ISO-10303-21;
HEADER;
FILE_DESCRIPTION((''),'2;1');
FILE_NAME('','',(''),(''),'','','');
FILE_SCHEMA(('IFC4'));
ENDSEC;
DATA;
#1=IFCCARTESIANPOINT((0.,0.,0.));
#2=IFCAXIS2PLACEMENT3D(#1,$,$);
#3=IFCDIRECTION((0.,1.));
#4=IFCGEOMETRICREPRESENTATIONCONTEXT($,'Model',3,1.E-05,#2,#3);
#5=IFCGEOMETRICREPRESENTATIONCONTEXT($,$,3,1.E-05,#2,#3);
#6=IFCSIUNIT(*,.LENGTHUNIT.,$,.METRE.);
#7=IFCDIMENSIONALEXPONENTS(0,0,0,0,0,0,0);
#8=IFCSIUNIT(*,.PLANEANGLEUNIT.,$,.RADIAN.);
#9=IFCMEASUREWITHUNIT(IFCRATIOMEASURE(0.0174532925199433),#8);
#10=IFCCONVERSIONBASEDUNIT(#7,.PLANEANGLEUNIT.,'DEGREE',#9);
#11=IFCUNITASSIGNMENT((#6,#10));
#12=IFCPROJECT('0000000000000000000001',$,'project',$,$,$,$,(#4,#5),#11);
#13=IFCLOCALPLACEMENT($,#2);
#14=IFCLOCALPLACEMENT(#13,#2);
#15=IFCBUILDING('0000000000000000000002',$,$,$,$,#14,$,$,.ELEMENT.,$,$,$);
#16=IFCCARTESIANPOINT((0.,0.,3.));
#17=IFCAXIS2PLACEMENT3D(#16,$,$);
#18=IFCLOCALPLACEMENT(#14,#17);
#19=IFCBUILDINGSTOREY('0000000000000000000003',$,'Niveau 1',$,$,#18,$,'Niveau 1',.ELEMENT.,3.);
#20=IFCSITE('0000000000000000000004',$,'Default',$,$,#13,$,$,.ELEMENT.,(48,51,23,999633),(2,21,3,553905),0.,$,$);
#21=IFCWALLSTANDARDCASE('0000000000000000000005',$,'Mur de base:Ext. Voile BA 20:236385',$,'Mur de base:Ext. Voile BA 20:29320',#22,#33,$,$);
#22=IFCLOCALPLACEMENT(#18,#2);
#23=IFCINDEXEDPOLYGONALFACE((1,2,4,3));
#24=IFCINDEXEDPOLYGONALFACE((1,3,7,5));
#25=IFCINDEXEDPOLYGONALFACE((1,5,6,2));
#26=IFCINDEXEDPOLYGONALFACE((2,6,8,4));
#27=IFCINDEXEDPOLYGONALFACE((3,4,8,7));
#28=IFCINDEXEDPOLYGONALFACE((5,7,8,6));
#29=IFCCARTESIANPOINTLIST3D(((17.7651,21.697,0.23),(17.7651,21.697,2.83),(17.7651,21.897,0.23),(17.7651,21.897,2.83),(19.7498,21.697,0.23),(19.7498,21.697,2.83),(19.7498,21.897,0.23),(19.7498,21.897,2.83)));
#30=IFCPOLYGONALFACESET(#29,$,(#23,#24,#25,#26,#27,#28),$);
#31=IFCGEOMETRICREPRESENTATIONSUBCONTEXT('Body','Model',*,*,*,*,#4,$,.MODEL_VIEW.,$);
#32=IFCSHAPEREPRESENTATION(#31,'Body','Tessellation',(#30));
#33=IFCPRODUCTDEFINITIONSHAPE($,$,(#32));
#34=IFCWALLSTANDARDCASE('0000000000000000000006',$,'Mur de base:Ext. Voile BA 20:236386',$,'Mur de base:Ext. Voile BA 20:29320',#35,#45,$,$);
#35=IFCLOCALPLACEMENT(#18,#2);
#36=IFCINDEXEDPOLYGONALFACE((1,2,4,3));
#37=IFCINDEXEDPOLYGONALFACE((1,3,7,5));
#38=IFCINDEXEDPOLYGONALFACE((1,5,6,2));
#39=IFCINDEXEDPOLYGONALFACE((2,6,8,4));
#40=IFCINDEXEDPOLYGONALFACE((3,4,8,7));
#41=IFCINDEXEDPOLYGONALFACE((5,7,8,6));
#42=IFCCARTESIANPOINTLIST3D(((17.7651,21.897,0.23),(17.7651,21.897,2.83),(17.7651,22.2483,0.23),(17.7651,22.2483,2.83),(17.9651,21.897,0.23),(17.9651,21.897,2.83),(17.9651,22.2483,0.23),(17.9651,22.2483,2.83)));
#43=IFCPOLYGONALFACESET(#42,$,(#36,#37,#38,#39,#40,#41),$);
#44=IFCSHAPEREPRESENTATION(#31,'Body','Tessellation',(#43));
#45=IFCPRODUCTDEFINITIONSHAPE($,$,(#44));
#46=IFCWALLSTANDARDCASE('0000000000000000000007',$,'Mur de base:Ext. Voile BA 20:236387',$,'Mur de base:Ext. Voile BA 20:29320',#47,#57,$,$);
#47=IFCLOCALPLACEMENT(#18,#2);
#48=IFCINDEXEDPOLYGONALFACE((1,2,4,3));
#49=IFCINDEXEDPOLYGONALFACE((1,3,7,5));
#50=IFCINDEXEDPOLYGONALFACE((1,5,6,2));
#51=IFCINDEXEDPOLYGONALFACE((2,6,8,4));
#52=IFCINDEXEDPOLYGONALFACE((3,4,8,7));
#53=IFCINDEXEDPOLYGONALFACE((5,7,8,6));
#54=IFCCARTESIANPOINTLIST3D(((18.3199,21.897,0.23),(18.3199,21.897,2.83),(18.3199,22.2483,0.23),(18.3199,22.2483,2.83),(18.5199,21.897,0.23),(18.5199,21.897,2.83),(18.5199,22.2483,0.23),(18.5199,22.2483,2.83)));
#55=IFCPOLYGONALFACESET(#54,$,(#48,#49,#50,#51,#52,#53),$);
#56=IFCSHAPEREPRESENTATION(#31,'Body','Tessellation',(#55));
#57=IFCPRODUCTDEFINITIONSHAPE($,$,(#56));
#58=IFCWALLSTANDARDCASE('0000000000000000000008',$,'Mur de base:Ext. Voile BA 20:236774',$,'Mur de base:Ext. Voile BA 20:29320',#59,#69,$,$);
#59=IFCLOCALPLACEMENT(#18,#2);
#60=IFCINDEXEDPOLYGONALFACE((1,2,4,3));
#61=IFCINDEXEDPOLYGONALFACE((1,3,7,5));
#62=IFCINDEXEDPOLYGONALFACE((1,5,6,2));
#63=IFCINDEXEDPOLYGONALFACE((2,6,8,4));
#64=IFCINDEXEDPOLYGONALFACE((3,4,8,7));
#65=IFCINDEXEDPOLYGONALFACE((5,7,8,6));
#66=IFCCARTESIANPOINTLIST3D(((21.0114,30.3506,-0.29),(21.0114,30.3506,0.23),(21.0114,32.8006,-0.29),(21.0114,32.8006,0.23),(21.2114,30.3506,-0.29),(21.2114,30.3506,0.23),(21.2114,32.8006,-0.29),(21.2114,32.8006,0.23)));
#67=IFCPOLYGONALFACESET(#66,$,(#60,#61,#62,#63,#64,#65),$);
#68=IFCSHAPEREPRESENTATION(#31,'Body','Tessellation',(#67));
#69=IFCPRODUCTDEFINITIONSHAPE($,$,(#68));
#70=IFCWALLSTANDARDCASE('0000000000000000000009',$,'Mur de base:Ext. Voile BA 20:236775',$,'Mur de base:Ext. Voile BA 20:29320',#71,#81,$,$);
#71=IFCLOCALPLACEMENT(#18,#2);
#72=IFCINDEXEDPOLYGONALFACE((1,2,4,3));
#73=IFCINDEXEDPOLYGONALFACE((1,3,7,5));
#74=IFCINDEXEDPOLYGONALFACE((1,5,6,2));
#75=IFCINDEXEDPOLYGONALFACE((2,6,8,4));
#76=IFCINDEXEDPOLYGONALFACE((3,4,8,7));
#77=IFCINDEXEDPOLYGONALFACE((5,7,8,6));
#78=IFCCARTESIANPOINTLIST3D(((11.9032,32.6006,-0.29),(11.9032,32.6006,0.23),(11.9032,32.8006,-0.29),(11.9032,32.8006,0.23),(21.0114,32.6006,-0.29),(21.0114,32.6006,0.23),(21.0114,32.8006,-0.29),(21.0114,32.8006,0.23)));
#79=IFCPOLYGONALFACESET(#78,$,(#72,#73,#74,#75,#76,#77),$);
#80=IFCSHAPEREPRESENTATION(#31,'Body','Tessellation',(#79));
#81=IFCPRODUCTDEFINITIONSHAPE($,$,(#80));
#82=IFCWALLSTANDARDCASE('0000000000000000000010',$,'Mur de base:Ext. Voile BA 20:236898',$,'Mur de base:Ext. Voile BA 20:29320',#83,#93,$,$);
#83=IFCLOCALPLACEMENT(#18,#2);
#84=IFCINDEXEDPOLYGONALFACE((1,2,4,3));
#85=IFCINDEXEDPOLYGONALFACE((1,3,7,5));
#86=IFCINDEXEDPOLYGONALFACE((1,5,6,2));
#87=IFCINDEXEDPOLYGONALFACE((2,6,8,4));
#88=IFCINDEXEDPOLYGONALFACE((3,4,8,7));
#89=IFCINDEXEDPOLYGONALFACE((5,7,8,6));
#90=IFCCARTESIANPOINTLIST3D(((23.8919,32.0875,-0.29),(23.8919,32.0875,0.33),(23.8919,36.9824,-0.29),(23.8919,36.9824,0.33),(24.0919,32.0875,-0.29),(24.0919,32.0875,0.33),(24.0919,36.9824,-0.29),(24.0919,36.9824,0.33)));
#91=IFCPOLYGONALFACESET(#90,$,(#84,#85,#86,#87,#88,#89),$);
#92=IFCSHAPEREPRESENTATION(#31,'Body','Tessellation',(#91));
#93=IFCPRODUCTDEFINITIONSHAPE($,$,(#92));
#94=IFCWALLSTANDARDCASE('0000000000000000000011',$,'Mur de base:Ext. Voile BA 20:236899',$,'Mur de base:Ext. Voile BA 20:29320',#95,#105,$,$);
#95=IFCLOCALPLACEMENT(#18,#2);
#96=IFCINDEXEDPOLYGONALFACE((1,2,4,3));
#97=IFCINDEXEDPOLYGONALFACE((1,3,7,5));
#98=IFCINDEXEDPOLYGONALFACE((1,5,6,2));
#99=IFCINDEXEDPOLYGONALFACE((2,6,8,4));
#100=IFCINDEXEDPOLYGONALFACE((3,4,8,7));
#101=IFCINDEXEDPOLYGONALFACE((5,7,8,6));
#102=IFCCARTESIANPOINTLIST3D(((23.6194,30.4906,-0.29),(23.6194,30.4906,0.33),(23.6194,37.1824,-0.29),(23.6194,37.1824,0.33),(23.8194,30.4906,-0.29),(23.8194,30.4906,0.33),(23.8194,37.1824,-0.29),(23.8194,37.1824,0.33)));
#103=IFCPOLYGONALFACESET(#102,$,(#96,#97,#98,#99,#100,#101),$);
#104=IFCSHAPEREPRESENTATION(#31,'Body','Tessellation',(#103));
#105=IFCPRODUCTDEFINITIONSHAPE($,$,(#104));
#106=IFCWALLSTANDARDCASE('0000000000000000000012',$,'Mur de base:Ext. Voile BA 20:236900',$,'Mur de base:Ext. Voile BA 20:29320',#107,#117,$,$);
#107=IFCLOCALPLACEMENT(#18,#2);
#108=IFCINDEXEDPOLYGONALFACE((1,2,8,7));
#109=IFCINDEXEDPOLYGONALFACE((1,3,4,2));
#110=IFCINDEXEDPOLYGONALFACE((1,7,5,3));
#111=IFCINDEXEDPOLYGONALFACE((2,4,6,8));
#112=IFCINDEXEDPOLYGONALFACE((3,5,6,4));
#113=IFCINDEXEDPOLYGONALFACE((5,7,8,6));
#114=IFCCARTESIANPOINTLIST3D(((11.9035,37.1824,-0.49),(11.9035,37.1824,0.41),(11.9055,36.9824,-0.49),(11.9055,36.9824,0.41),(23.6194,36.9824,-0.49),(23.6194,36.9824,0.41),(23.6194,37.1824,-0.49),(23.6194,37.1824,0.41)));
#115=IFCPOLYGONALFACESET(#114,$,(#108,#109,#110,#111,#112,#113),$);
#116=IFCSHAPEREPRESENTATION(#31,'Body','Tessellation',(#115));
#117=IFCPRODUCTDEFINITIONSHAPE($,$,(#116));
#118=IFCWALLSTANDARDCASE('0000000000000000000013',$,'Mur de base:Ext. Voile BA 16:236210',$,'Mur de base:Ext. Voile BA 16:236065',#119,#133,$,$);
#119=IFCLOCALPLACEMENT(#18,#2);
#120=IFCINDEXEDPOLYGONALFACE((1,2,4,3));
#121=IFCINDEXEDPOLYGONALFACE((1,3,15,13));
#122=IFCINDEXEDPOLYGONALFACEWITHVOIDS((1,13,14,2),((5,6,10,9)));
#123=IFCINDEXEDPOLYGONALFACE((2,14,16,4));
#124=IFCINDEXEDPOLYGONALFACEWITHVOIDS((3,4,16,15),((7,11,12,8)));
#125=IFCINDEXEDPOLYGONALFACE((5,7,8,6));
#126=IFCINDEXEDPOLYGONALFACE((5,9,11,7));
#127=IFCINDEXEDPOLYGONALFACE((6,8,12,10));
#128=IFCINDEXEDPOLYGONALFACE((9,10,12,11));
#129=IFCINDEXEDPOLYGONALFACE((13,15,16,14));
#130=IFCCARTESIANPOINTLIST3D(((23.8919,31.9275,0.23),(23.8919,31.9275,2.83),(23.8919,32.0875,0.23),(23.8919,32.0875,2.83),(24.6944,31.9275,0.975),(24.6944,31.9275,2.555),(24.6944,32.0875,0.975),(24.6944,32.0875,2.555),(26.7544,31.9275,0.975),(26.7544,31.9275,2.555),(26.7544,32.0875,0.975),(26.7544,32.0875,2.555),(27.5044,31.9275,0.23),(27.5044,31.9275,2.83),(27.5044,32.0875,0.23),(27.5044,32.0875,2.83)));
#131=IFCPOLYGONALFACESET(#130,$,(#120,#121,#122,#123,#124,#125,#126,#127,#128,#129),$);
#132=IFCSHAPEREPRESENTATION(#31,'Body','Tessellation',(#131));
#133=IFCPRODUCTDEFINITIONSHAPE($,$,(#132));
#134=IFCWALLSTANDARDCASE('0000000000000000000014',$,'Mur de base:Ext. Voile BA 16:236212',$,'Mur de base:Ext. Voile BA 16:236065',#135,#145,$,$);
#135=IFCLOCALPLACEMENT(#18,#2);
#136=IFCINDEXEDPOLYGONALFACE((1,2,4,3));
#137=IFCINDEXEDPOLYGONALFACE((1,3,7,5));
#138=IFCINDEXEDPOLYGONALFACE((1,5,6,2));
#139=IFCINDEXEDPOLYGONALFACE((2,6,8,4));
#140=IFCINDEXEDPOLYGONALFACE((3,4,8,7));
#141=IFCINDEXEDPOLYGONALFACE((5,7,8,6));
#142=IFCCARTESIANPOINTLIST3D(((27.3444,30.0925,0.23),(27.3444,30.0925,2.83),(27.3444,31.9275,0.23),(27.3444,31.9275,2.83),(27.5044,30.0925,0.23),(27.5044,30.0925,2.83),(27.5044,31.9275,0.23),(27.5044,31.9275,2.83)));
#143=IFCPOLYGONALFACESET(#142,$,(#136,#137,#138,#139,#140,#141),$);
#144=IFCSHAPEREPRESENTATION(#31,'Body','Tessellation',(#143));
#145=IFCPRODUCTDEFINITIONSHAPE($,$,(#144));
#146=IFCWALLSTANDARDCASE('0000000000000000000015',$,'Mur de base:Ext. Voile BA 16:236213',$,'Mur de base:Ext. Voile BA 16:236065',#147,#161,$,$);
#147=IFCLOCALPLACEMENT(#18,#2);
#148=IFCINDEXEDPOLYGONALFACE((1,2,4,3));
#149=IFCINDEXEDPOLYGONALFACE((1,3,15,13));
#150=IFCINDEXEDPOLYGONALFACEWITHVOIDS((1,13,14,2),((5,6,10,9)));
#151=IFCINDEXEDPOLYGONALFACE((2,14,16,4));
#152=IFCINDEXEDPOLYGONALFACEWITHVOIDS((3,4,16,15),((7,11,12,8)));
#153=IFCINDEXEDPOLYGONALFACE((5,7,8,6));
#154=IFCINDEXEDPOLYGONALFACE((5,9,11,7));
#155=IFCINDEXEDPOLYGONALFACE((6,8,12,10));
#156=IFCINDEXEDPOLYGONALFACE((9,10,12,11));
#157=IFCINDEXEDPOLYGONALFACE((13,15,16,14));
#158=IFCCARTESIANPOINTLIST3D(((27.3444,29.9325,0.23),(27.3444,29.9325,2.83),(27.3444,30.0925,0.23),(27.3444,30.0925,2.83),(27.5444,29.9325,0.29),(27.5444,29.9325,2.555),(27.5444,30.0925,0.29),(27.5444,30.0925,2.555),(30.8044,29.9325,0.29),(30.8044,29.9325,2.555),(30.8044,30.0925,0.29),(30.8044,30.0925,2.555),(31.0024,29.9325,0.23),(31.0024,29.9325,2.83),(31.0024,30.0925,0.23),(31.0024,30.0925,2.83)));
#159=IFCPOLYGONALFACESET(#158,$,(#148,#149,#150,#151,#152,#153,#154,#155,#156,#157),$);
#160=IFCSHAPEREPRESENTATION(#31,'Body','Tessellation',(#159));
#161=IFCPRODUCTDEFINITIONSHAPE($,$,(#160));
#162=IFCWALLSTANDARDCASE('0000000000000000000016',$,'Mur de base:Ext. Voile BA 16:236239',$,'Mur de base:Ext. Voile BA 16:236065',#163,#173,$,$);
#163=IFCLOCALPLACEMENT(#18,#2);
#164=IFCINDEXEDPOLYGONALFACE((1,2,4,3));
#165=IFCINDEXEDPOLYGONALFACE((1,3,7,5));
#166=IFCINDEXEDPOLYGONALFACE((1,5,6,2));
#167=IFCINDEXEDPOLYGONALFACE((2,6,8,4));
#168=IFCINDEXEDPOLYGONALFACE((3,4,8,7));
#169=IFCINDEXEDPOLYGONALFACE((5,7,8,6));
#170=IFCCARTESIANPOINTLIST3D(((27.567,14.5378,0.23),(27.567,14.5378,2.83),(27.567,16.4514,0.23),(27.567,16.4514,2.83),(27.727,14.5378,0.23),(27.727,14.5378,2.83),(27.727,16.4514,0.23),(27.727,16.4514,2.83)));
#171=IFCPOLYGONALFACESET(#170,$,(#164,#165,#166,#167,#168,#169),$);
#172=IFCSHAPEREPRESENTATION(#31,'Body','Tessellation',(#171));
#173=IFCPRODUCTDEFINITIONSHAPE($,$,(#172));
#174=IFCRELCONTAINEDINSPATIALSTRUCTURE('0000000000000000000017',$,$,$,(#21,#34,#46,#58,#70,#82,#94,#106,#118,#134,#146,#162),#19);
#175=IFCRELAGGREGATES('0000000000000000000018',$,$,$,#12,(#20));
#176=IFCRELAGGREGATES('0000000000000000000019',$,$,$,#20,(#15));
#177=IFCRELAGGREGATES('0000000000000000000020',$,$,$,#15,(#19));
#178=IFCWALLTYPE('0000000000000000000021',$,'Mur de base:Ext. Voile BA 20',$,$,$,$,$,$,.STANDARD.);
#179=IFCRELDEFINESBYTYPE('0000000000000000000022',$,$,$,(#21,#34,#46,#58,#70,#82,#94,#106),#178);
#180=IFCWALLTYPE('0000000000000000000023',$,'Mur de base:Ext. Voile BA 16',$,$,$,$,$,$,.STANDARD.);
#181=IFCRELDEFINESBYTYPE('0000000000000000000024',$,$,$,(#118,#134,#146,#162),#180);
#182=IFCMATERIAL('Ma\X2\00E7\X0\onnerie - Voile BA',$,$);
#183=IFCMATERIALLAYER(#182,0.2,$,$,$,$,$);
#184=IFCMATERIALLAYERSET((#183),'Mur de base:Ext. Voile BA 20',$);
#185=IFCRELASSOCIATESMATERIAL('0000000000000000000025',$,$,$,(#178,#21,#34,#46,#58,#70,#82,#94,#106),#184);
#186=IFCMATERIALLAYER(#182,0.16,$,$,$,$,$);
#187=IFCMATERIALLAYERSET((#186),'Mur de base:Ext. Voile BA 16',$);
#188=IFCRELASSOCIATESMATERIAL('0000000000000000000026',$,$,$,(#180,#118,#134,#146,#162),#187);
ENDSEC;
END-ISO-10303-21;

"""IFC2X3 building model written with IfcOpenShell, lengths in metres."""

from ifc_helpers import new_model, entity, si_unit, converted_unit, direction, frame, frame_2d, origin, origin_2d_with_axis, place, context, subcontext, project, spatial, polyline, rectangle, outline, extrude, material, layer, layer_set, layer_usage, type_object, element, save


model = new_model("IFC2X3")

# Units and contexts
model_context = context("Model", 3, precision=1e-05, world=origin(), true_north=direction((0.0, 1.0)))
context_of_model = context(None, 3, precision=1e-05, world=origin(), true_north=direction((0.0, 1.0)))
body_context = subcontext(model_context, "Body", "Model", "MODEL_VIEW")
ifc_project = project(units=[si_unit("LENGTHUNIT", "METRE"), converted_unit("PLANEANGLEUNIT", "DEGREE", entity("IfcRatioMeasure", 0.0174532925199433), si_unit("PLANEANGLEUNIT", "RADIAN"), dimensions=[0, 0, 0, 0, 0, 0, 0])], contexts=[model_context, context_of_model])

# Site, building, storey
site_placement = place(None, origin())
site = spatial("IfcSite", under=ifc_project, at=site_placement, Name="Default", CompositionType="ELEMENT", RefLatitude=(48, 51, 23, 999633), RefLongitude=(2, 21, 3, 553905), RefElevation=0.0)
building_placement = place(site_placement, origin())
building = spatial("IfcBuilding", under=site, at=building_placement, CompositionType="ELEMENT")
storey_placement = place(building_placement, frame((0.0, 0.0, 3.0)))
storey = spatial("IfcBuildingStorey", under=building, at=storey_placement, Name="Niveau 1", LongName="Niveau 1", CompositionType="ELEMENT", Elevation=3.0)

# Shared definitions
ifc_material = material(Name="Maçonnerie - Voile BA")
ifc_layer_1 = layer(ifc_material, 0.2)
ifc_layer_set_1 = layer_set([ifc_layer_1], Name="Mur de base:Ext. Voile BA 20")
wall_type_1 = type_object("IfcWallType", Name="Mur de base:Ext. Voile BA 20", PredefinedType="STANDARD", material=ifc_layer_set_1)

# Walls
ifc_layer_usage_1 = layer_usage(ifc_layer_set_1, "AXIS2", "NEGATIVE", 0.1)
wall_1_placement = place(storey_placement, frame((19.7498, 21.797, 0.23), z_axis=(0.0, 0.0, 1.0), x_axis=(-1.0, 0.0, 0.0)))
element("IfcWallStandardCase", 1, at=wall_1_placement, inside=storey, type_object=wall_type_1, material=ifc_layer_usage_1, Name="Mur de base:Ext. Voile BA 20:236385", ObjectType="Mur de base:Ext. Voile BA 20:29320", context=body_context, shape_type="SweptSolid", body=[
    extrude(rectangle(XDim=1.9848, YDim=0.2, at=frame_2d((0.9924, 0.0), x_axis=(-1.0, 0.0))), origin(), (0.0, 0.0, 1.0), 2.6),
])
ifc_layer_usage_2 = layer_usage(ifc_layer_set_1, "AXIS2", "NEGATIVE", 0.1)
wall_2_placement = place(storey_placement, frame((17.8651, 22.2483, 0.23), z_axis=(0.0, 0.0, 1.0), x_axis=(0.0, -1.0, 0.0)))
element("IfcWallStandardCase", 2, at=wall_2_placement, inside=storey, type_object=wall_type_1, material=ifc_layer_usage_2, Name="Mur de base:Ext. Voile BA 20:236386", ObjectType="Mur de base:Ext. Voile BA 20:29320", context=body_context, shape_type="SweptSolid", body=[
    extrude(rectangle(XDim=0.3513, YDim=0.2, at=frame_2d((0.1756, 0.0), x_axis=(-1.0, 0.0))), origin(), (0.0, 0.0, 1.0), 2.6),
])
ifc_layer_usage_3 = layer_usage(ifc_layer_set_1, "AXIS2", "NEGATIVE", 0.1)
wall_3_placement = place(storey_placement, frame((18.4199, 22.2483, 0.23), z_axis=(0.0, 0.0, 1.0), x_axis=(0.0, -1.0, 0.0)))
element("IfcWallStandardCase", 3, at=wall_3_placement, inside=storey, type_object=wall_type_1, material=ifc_layer_usage_3, Name="Mur de base:Ext. Voile BA 20:236387", ObjectType="Mur de base:Ext. Voile BA 20:29320", context=body_context, shape_type="SweptSolid", body=[
    extrude(rectangle(XDim=0.3513, YDim=0.2, at=frame_2d((0.1756, 0.0), x_axis=(-1.0, 0.0))), origin(), (0.0, 0.0, 1.0), 2.6),
])
ifc_layer_usage_4 = layer_usage(ifc_layer_set_1, "AXIS2", "NEGATIVE", 0.1)
wall_4_placement = place(storey_placement, frame((21.1114, 30.3506, -0.29), z_axis=(0.0, 0.0, 1.0), x_axis=(0.0, 1.0, 0.0)))
element("IfcWallStandardCase", 4, at=wall_4_placement, inside=storey, type_object=wall_type_1, material=ifc_layer_usage_4, Name="Mur de base:Ext. Voile BA 20:236774", ObjectType="Mur de base:Ext. Voile BA 20:29320", context=body_context, shape_type="SweptSolid", body=[
    extrude(rectangle(XDim=2.45, YDim=0.2, at=frame_2d((1.225, 0.0), x_axis=(-1.0, 0.0))), origin(), (0.0, 0.0, 1.0), 0.52),
])
ifc_layer_usage_5 = layer_usage(ifc_layer_set_1, "AXIS2", "NEGATIVE", 0.1)
wall_5_placement = place(storey_placement, frame((21.0114, 32.7006, -0.29), z_axis=(0.0, 0.0, 1.0), x_axis=(-1.0, 0.0, 0.0)))
element("IfcWallStandardCase", 5, at=wall_5_placement, inside=storey, type_object=wall_type_1, material=ifc_layer_usage_5, Name="Mur de base:Ext. Voile BA 20:236775", ObjectType="Mur de base:Ext. Voile BA 20:29320", context=body_context, shape_type="SweptSolid", body=[
    extrude(rectangle(XDim=9.1082, YDim=0.2, at=frame_2d((4.5541, 0.0), x_axis=(-1.0, 0.0))), origin(), (0.0, 0.0, 1.0), 0.52),
])
ifc_layer_usage_6 = layer_usage(ifc_layer_set_1, "AXIS2", "NEGATIVE", 0.1)
wall_6_placement = place(storey_placement, frame((23.9919, 32.0875, -0.29), z_axis=(0.0, 0.0, 1.0), x_axis=(0.0, 1.0, 0.0)))
element("IfcWallStandardCase", 6, at=wall_6_placement, inside=storey, type_object=wall_type_1, material=ifc_layer_usage_6, Name="Mur de base:Ext. Voile BA 20:236898", ObjectType="Mur de base:Ext. Voile BA 20:29320", context=body_context, shape_type="SweptSolid", body=[
    extrude(rectangle(XDim=4.8949, YDim=0.2, at=frame_2d((2.4475, 0.0), x_axis=(-1.0, 0.0))), origin(), (0.0, 0.0, 1.0), 0.62),
])
ifc_layer_usage_7 = layer_usage(ifc_layer_set_1, "AXIS2", "POSITIVE", -0.1)
wall_7_placement = place(storey_placement, frame((23.7194, 30.4906, -0.29), z_axis=(0.0, 0.0, 1.0), x_axis=(0.0, 1.0, 0.0)))
element("IfcWallStandardCase", 7, at=wall_7_placement, inside=storey, type_object=wall_type_1, material=ifc_layer_usage_7, Name="Mur de base:Ext. Voile BA 20:236899", ObjectType="Mur de base:Ext. Voile BA 20:29320", context=body_context, shape_type="SweptSolid", body=[
    extrude(rectangle(XDim=6.6918, YDim=0.2, at=frame_2d((3.3459, 0.0), x_axis=(-1.0, 0.0))), origin(), (0.0, 0.0, 1.0), 0.62),
])
ifc_layer_usage_8 = layer_usage(ifc_layer_set_1, "AXIS2", "POSITIVE", -0.1)
wall_8_placement = place(storey_placement, frame((23.6194, 37.0824, -0.49), z_axis=(0.0, 0.0, 1.0), x_axis=(-1.0, 0.0, 0.0)))
element("IfcWallStandardCase", 8, at=wall_8_placement, inside=storey, type_object=wall_type_1, material=ifc_layer_usage_8, Name="Mur de base:Ext. Voile BA 20:236900", ObjectType="Mur de base:Ext. Voile BA 20:29320", context=body_context, shape_type="SweptSolid", body=[
    extrude(outline(polyline([(11.7159, -0.1), (11.7139, 0.1), (0.0, 0.1), (0.0, -0.1), (11.7159, -0.1)])), origin(), (0.0, 0.0, 1.0), 0.9),
])

# Wall, opening
ifc_layer_2 = layer(ifc_material, 0.16)
ifc_layer_set_2 = layer_set([ifc_layer_2], Name="Mur de base:Ext. Voile BA 16")
ifc_layer_usage_9 = layer_usage(ifc_layer_set_2, "AXIS2", "NEGATIVE", 0.08)
wall_type_2 = type_object("IfcWallType", Name="Mur de base:Ext. Voile BA 16", PredefinedType="STANDARD", material=ifc_layer_set_2)
wall_9_placement = place(storey_placement, frame((23.8919, 32.0075, 0.23)))
wall_9 = element("IfcWallStandardCase", 9, at=wall_9_placement, inside=storey, type_object=wall_type_2, material=ifc_layer_usage_9, Name="Mur de base:Ext. Voile BA 16:236210", ObjectType="Mur de base:Ext. Voile BA 16:236065", context=body_context, shape_type="SweptSolid", body=[
    extrude(rectangle(XDim=3.6124, YDim=0.16, at=frame_2d((1.8062, 0.0), x_axis=(-1.0, 0.0))), origin(), (0.0, 0.0, 1.0), 2.6),
])
opening_1_placement = place(wall_9_placement, origin())
element("IfcOpeningElement", 10, at=opening_1_placement, cuts=wall_9, ObjectType="Opening", context=body_context, shape_type="SweptSolid", body=[
    extrude(rectangle(XDim=1.58, YDim=2.06, at=frame_2d((0.0, 0.0), x_axis=(1.0, 0.0))), frame((1.8324, -0.08, 1.535), z_axis=(0.0, 1.0, 0.0), x_axis=(0.0, 0.0, -1.0)), (0.0, 0.0, 1.0), 0.16),
])

# Wall
ifc_layer_usage_10 = layer_usage(ifc_layer_set_2, "AXIS2", "NEGATIVE", 0.08)
wall_10_placement = place(storey_placement, frame((27.4244, 31.9275, 0.23), z_axis=(0.0, 0.0, 1.0), x_axis=(0.0, -1.0, 0.0)))
element("IfcWallStandardCase", 11, at=wall_10_placement, inside=storey, type_object=wall_type_2, material=ifc_layer_usage_10, Name="Mur de base:Ext. Voile BA 16:236212", ObjectType="Mur de base:Ext. Voile BA 16:236065", context=body_context, shape_type="SweptSolid", body=[
    extrude(rectangle(XDim=1.835, YDim=0.16, at=frame_2d((0.9175, 0.0), x_axis=(-1.0, 0.0))), origin(), (0.0, 0.0, 1.0), 2.6),
])

# Wall, opening
ifc_layer_usage_11 = layer_usage(ifc_layer_set_2, "AXIS2", "NEGATIVE", 0.08)
wall_11_placement = place(storey_placement, frame((27.3444, 30.0125, 0.23)))
wall_11 = element("IfcWallStandardCase", 12, at=wall_11_placement, inside=storey, type_object=wall_type_2, material=ifc_layer_usage_11, Name="Mur de base:Ext. Voile BA 16:236213", ObjectType="Mur de base:Ext. Voile BA 16:236065", context=body_context, shape_type="SweptSolid", body=[
    extrude(rectangle(XDim=3.658, YDim=0.16, at=frame_2d((1.829, 0.0), x_axis=(-1.0, 0.0))), origin(), (0.0, 0.0, 1.0), 2.6),
])
opening_2_placement = place(wall_11_placement, origin())
element("IfcOpeningElement", 13, at=opening_2_placement, cuts=wall_11, ObjectType="Opening", context=body_context, shape_type="SweptSolid", body=[
    extrude(rectangle(XDim=2.265, YDim=3.26, at=origin_2d_with_axis()), frame((1.83, -0.08, 1.1925), z_axis=(0.0, 1.0, 0.0), x_axis=(0.0, 0.0, -1.0)), (0.0, 0.0, 1.0), 0.16),
])

# Wall
ifc_layer_usage_12 = layer_usage(ifc_layer_set_2, "AXIS2", "NEGATIVE", 0.08)
wall_12_placement = place(storey_placement, frame((27.647, 16.4514, 0.23), z_axis=(0.0, 0.0, 1.0), x_axis=(0.0, -1.0, 0.0)))
element("IfcWallStandardCase", 14, at=wall_12_placement, inside=storey, type_object=wall_type_2, material=ifc_layer_usage_12, Name="Mur de base:Ext. Voile BA 16:236239", ObjectType="Mur de base:Ext. Voile BA 16:236065", context=body_context, shape_type="SweptSolid", body=[
    extrude(rectangle(XDim=1.9136, YDim=0.16, at=frame_2d((0.9568, 0.0), x_axis=(-1.0, 0.0))), origin(), (0.0, 0.0, 1.0), 2.6),
])

save(model, "model.ifc")
